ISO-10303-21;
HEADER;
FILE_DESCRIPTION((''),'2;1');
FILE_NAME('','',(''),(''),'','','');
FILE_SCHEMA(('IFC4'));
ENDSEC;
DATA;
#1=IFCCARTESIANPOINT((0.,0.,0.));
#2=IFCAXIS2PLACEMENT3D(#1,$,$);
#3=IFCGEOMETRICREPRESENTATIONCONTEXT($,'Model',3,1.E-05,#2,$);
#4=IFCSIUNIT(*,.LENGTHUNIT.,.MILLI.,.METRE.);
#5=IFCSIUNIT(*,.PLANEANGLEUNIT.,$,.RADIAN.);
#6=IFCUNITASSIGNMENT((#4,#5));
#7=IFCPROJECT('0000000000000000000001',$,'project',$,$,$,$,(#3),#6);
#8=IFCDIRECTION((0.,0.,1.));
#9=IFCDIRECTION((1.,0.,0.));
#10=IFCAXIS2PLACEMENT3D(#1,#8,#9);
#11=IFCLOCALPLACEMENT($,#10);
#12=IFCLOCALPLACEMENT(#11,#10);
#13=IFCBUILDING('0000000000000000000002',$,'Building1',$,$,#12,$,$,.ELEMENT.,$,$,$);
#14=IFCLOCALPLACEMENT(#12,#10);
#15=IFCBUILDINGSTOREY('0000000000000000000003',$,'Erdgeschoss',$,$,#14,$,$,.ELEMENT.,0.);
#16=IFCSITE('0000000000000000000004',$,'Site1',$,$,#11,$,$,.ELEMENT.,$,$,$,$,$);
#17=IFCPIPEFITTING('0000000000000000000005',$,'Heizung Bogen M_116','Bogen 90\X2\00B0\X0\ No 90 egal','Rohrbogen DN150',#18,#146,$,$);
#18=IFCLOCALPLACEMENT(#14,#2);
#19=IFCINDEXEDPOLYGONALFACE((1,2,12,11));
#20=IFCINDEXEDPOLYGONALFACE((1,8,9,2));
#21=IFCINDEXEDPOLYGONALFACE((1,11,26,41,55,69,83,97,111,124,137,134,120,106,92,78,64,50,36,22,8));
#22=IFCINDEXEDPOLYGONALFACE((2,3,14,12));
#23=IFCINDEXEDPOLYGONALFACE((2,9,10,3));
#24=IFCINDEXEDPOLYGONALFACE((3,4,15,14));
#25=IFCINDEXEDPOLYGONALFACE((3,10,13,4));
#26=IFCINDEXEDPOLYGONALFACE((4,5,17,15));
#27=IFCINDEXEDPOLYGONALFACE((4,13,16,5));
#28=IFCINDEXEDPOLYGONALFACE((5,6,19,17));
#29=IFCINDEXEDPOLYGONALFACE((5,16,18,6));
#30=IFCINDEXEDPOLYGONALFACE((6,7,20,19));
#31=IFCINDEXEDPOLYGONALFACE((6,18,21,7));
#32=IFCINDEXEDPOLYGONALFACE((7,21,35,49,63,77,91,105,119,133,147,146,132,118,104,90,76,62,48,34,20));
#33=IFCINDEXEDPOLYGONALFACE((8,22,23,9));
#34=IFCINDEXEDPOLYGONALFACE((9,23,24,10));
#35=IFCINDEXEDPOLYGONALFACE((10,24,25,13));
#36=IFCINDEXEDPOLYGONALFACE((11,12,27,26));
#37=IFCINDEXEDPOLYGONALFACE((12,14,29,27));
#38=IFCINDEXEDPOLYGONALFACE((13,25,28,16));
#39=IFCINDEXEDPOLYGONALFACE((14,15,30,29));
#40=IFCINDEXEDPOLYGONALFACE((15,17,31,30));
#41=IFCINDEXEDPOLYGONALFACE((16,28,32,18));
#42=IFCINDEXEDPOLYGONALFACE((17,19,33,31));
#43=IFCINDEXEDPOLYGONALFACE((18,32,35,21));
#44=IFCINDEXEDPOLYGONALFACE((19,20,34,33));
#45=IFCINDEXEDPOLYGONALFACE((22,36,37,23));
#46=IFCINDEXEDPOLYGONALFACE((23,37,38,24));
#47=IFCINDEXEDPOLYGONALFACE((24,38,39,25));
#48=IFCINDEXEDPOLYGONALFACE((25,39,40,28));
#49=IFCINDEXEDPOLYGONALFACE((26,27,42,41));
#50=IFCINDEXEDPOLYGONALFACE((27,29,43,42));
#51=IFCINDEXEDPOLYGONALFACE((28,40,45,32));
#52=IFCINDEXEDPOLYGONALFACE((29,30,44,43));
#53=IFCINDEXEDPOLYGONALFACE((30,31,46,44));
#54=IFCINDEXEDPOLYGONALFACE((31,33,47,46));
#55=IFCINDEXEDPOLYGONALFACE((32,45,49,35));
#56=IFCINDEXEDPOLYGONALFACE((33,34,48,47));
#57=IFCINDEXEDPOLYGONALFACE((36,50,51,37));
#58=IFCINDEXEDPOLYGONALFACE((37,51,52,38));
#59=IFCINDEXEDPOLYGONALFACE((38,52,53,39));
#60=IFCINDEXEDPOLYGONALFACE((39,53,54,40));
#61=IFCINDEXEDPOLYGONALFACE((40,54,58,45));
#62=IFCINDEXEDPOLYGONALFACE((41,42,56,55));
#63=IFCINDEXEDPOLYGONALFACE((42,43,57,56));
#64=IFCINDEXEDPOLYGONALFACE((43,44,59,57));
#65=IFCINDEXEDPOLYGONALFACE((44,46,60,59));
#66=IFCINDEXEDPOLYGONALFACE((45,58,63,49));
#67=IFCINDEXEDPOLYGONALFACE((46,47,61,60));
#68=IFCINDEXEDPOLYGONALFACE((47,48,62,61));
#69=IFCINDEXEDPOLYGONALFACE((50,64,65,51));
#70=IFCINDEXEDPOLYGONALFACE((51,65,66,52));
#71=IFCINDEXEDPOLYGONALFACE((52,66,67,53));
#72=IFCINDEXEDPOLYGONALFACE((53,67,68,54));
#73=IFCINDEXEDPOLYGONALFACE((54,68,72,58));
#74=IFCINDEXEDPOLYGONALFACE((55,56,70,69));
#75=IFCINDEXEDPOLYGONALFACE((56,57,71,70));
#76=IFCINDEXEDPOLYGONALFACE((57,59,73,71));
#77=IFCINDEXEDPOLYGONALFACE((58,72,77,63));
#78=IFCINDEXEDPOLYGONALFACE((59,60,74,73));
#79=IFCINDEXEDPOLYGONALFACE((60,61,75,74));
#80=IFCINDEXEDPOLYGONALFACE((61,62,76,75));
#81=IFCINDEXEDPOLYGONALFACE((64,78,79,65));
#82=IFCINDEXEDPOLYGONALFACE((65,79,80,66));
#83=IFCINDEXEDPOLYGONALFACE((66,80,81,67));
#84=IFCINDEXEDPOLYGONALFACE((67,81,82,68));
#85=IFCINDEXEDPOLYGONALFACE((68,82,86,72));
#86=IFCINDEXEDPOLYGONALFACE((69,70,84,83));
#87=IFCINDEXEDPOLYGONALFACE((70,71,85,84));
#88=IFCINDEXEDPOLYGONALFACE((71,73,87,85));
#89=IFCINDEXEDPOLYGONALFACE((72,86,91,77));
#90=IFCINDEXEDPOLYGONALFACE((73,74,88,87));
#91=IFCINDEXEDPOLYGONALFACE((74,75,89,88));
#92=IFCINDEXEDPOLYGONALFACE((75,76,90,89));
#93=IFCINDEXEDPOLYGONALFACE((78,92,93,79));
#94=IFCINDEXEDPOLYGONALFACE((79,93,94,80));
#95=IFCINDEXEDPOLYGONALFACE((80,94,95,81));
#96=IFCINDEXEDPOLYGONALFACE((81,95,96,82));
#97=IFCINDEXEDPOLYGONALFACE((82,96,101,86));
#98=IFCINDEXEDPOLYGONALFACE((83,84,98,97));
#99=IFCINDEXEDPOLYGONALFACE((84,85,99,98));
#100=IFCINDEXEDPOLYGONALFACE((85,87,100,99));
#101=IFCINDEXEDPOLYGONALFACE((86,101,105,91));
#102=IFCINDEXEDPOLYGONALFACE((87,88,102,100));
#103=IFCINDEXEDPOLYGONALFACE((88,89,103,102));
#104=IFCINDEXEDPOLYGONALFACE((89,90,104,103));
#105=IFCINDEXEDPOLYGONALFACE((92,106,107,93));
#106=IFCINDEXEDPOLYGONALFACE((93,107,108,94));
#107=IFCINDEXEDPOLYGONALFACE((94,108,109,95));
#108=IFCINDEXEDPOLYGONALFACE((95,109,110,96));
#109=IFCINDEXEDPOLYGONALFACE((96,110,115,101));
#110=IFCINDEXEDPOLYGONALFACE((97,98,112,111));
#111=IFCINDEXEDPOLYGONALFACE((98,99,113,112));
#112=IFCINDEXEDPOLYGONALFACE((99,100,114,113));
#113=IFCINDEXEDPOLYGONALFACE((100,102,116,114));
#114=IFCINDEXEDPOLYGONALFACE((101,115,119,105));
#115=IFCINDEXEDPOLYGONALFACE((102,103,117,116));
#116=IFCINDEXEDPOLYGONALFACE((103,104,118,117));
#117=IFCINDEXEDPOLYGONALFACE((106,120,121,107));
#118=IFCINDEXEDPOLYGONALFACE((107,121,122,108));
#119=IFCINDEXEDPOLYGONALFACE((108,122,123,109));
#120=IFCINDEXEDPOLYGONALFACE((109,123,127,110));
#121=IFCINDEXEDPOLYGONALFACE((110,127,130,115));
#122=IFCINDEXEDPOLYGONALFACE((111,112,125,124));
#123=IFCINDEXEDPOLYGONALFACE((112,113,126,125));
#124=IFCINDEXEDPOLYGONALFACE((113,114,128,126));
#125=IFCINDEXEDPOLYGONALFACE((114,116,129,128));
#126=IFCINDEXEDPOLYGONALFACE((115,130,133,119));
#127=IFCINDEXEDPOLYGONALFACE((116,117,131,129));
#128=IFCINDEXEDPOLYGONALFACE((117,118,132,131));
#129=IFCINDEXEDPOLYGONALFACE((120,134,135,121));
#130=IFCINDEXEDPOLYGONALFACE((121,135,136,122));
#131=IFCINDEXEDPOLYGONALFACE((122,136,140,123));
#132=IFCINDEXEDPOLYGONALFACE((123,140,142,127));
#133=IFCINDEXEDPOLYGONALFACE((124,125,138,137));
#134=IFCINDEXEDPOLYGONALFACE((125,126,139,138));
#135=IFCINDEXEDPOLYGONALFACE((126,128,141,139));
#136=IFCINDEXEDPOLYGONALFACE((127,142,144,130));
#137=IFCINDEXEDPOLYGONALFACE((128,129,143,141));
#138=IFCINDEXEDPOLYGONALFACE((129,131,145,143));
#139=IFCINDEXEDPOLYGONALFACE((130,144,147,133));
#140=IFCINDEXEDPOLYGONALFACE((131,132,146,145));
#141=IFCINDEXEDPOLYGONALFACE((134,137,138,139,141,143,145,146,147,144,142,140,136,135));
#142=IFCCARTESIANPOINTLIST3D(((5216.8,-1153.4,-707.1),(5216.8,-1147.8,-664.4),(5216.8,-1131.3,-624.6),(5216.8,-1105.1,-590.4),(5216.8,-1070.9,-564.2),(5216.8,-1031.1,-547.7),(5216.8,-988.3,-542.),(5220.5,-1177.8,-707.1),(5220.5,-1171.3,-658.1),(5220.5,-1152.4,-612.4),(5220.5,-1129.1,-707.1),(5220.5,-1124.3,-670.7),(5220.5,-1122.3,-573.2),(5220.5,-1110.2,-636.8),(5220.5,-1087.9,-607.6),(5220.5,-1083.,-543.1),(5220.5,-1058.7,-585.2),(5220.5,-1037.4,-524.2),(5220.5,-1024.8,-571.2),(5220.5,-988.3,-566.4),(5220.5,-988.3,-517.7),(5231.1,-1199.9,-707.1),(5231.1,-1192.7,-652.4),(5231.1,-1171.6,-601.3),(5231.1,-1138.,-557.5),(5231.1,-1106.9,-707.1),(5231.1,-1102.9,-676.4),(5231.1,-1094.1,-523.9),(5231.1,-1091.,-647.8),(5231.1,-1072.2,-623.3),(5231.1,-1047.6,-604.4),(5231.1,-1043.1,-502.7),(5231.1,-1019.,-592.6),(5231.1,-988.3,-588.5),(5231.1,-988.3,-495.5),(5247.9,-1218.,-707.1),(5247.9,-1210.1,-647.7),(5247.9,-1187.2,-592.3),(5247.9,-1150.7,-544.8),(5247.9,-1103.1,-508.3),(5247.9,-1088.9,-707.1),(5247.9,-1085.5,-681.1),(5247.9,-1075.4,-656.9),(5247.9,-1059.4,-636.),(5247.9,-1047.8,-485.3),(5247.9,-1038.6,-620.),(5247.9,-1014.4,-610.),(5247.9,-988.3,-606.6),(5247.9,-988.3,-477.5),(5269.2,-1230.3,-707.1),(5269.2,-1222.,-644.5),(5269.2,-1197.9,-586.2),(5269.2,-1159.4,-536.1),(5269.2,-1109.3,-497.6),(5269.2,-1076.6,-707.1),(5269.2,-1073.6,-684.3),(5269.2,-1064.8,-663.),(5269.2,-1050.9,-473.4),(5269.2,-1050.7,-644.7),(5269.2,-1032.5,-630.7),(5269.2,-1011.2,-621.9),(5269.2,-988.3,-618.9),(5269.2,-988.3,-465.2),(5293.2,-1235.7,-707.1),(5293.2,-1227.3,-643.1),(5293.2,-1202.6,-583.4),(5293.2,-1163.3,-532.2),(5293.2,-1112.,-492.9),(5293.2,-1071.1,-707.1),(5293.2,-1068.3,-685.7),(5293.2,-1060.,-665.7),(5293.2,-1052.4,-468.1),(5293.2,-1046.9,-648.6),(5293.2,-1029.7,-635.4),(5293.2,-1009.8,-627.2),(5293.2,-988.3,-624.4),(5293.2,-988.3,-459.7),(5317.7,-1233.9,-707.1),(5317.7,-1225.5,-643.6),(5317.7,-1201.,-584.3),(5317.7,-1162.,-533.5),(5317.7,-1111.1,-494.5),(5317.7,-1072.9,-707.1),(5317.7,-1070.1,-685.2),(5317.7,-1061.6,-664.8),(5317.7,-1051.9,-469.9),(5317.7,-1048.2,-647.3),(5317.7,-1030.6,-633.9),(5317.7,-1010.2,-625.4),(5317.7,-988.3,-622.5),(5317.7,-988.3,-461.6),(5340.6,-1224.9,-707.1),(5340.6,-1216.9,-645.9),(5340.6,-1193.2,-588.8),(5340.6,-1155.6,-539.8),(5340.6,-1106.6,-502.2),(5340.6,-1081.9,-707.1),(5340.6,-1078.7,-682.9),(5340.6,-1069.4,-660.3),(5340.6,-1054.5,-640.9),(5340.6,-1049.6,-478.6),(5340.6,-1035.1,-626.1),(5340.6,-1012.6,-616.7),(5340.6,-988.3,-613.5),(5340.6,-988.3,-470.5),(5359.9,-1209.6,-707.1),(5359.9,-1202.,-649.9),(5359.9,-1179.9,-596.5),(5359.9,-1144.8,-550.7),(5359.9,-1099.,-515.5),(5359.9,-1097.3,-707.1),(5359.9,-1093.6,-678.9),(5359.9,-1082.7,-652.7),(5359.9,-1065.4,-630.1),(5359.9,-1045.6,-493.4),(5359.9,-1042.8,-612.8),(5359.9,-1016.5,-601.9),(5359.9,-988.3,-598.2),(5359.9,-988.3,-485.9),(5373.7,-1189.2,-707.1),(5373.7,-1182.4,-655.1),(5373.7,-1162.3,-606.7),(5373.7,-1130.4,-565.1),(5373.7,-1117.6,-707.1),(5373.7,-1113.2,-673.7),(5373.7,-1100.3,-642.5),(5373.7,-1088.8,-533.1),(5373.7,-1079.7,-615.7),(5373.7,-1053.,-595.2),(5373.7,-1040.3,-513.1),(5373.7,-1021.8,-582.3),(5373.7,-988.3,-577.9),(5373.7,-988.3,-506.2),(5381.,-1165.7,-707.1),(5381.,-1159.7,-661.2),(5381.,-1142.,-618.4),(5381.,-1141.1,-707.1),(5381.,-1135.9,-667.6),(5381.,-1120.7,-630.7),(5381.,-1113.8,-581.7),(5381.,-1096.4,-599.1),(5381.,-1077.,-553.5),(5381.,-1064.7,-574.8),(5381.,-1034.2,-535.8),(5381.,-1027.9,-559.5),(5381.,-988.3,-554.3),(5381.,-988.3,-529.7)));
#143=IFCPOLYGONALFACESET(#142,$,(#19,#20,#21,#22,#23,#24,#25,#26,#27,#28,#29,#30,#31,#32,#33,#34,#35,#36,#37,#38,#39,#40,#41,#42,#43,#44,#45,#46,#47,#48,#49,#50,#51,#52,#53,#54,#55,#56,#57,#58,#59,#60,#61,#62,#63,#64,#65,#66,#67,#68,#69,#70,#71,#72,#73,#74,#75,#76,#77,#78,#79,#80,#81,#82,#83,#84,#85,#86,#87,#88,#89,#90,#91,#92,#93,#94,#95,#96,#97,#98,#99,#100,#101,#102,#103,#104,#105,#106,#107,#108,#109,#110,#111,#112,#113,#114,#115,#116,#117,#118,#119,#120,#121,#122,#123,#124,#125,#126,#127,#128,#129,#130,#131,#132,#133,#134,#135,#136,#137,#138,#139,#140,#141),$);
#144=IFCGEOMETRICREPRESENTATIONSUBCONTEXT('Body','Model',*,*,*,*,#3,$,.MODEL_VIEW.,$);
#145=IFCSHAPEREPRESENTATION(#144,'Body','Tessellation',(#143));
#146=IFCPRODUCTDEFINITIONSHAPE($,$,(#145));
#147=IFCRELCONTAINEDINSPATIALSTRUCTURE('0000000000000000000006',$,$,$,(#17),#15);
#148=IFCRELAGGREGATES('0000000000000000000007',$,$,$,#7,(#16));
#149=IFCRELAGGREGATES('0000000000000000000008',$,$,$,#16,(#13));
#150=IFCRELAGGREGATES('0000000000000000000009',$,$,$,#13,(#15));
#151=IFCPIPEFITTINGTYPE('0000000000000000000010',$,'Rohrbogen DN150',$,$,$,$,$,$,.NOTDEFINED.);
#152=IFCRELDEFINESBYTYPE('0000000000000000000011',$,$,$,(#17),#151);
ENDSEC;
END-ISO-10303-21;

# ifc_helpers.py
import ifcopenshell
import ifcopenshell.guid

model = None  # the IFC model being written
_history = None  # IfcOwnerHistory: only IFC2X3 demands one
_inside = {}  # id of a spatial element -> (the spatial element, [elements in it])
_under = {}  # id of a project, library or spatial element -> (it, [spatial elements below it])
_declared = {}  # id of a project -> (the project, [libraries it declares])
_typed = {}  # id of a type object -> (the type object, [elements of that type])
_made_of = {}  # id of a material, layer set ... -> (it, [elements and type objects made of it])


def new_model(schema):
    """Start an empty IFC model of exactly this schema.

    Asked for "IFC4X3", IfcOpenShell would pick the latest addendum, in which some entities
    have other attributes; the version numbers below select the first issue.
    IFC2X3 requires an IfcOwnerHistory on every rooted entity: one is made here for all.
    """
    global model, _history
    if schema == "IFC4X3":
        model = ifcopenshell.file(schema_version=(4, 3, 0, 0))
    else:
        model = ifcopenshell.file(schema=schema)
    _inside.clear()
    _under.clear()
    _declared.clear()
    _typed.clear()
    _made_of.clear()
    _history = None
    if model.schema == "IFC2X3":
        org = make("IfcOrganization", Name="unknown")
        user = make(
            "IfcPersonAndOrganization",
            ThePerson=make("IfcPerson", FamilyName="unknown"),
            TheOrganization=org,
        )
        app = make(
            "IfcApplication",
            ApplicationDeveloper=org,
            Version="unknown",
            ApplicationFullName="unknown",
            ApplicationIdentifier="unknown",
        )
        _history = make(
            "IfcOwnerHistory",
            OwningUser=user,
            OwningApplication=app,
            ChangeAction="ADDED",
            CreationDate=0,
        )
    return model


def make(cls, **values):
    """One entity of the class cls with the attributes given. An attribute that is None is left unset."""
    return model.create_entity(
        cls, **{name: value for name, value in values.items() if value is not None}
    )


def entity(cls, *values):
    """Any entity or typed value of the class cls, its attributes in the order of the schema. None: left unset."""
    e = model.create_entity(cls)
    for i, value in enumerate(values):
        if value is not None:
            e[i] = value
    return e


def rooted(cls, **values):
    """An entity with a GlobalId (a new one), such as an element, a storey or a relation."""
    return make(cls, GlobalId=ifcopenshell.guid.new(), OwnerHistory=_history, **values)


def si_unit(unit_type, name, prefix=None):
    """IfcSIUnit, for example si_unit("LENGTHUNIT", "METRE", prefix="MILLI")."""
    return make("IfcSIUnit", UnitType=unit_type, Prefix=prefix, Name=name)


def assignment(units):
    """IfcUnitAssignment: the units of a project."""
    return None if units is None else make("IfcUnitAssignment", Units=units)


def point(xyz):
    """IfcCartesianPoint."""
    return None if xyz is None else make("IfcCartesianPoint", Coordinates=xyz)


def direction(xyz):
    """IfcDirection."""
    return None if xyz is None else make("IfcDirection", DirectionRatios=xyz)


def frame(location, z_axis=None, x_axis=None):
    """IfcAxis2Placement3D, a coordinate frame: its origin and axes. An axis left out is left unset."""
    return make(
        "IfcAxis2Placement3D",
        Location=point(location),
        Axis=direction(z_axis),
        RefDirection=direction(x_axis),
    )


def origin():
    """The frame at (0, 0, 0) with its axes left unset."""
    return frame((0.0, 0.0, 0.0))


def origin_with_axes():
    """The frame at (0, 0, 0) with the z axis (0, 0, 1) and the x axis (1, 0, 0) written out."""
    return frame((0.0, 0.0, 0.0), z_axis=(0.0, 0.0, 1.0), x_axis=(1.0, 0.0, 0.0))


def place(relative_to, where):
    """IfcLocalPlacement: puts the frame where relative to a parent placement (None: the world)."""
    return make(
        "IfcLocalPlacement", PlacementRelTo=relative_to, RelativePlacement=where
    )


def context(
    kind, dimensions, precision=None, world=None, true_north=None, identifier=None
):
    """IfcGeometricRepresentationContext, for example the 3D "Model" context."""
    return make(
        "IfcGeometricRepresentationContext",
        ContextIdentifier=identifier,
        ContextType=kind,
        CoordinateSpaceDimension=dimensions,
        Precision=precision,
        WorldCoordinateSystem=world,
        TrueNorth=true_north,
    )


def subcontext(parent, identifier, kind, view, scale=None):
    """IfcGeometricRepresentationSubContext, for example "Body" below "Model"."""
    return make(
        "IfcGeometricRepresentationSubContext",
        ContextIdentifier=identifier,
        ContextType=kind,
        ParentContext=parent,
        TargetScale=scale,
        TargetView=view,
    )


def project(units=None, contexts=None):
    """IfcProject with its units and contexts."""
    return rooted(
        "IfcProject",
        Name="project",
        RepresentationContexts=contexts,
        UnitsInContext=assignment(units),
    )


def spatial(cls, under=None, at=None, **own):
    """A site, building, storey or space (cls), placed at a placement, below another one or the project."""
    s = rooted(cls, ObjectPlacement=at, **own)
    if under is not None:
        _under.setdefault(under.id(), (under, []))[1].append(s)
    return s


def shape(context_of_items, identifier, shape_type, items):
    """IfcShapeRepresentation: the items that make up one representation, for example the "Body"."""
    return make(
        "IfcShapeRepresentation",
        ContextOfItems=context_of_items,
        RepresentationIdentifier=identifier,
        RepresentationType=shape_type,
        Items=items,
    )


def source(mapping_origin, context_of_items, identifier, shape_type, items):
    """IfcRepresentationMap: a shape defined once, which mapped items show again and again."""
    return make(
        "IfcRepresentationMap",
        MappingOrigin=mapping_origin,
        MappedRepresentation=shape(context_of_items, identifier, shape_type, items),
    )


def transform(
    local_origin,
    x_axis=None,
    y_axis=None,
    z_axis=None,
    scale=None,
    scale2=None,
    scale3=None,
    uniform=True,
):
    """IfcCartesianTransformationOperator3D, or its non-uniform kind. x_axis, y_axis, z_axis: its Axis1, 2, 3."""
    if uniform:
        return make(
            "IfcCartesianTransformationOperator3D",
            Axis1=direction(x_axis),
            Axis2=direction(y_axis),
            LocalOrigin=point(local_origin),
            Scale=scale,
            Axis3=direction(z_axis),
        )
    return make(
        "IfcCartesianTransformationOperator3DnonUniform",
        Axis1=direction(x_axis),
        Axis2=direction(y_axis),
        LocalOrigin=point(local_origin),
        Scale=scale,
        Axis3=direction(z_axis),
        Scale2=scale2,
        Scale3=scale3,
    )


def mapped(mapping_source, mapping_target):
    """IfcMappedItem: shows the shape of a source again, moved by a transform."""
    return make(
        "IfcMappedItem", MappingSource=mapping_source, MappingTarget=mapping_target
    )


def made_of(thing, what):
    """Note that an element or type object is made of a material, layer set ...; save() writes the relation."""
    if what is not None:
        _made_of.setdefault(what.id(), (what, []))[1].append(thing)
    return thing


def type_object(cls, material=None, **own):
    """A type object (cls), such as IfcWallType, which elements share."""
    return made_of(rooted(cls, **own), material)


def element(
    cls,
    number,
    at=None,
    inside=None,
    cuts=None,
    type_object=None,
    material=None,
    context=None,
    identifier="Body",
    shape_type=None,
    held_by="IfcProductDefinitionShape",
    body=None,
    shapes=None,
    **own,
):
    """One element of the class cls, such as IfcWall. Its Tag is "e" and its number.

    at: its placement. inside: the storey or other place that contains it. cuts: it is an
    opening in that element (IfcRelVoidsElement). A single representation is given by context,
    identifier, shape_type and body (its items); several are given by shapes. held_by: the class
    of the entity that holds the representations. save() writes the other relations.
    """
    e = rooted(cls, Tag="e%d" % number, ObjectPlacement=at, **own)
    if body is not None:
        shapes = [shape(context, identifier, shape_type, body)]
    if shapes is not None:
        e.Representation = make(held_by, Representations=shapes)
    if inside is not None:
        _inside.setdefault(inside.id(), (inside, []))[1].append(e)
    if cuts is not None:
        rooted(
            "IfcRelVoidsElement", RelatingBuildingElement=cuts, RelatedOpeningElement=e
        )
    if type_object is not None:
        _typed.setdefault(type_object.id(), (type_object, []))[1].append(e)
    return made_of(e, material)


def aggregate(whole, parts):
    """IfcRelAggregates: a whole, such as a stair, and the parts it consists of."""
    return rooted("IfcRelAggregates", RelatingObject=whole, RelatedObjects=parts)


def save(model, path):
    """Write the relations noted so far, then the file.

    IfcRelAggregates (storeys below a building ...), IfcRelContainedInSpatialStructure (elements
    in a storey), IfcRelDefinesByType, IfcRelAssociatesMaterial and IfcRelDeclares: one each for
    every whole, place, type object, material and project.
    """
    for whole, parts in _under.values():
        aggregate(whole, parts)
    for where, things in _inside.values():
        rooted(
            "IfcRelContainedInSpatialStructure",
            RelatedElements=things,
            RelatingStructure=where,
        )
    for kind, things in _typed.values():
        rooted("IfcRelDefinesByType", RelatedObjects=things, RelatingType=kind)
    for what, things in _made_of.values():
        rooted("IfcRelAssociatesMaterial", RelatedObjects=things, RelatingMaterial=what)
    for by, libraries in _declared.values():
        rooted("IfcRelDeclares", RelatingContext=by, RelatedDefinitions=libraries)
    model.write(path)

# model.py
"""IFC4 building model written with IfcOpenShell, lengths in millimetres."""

from ifc_helpers import new_model, entity, si_unit, frame, origin, origin_with_axes, place, context, subcontext, project, spatial, source, transform, mapped, type_object, element, save


model = new_model("IFC4")

# Units and contexts
model_context = context("Model", 3, precision=1e-05, world=origin())
body_context = subcontext(model_context, "Body", "Model", "MODEL_VIEW")
ifc_project = project(units=[si_unit("LENGTHUNIT", "METRE", prefix="MILLI"), si_unit("PLANEANGLEUNIT", "RADIAN")], contexts=[model_context])

# Site, building, storey
site_placement = place(None, origin_with_axes())
site = spatial("IfcSite", under=ifc_project, at=site_placement, Name="Site1", CompositionType="ELEMENT")
building_placement = place(site_placement, origin_with_axes())
building = spatial("IfcBuilding", under=site, at=building_placement, Name="Building1", CompositionType="ELEMENT")
storey_placement = place(building_placement, origin_with_axes())
storey = spatial("IfcBuildingStorey", under=building, at=storey_placement, Name="Erdgeschoss", CompositionType="ELEMENT", Elevation=0.0)

# Pipe fitting
pipe_fitting_type_1 = type_object("IfcPipeFittingType", Name="Rohrbogen DN150", PredefinedType="NOTDEFINED")
shared_shape_1 = source(origin_with_axes(), body_context, "Body", "SolidModel", [
    entity("IfcRevolvedAreaSolid", entity("IfcCircleProfileDef", "AREA", None, entity("IfcAxis2Placement2D", entity("IfcCartesianPoint", [0.0, 0.0]), entity("IfcDirection", [1.0, 0.0])), 82.5), entity("IfcAxis2Placement3D", entity("IfcCartesianPoint", [-123.8, 0.0, 41.3]), entity("IfcDirection", [1.0, 0.0, 0.0]), entity("IfcDirection", [0.0, -1.0, 0.0])), entity("IfcAxis1Placement", entity("IfcCartesianPoint", [0.0, 165.1, 0.0]), entity("IfcDirection", [-1.0, 0.0, 0.0])), 1.570796),
])
pipe_fitting_1_placement = place(storey_placement, frame((5299.4, -1112.2, -583.3), z_axis=(0.0, 0.0, 1.0), x_axis=(1.0, 0.0, 0.0)))
element("IfcPipeFitting", 1, at=pipe_fitting_1_placement, inside=storey, type_object=pipe_fitting_type_1, Name="Heizung Bogen M_116", Description="Bogen 90° No 90 egal", ObjectType="Rohrbogen DN150", context=body_context, shape_type="MappedRepresentation", body=[
    mapped(shared_shape_1, transform((0.0, 0.0, 0.0), x_axis=(0.0, -1.0, 0.0), y_axis=(1.0, 0.0, 0.0), z_axis=(0.0, 0.0, 1.0), scale=1.0)),
])

save(model, "model.ifc")
